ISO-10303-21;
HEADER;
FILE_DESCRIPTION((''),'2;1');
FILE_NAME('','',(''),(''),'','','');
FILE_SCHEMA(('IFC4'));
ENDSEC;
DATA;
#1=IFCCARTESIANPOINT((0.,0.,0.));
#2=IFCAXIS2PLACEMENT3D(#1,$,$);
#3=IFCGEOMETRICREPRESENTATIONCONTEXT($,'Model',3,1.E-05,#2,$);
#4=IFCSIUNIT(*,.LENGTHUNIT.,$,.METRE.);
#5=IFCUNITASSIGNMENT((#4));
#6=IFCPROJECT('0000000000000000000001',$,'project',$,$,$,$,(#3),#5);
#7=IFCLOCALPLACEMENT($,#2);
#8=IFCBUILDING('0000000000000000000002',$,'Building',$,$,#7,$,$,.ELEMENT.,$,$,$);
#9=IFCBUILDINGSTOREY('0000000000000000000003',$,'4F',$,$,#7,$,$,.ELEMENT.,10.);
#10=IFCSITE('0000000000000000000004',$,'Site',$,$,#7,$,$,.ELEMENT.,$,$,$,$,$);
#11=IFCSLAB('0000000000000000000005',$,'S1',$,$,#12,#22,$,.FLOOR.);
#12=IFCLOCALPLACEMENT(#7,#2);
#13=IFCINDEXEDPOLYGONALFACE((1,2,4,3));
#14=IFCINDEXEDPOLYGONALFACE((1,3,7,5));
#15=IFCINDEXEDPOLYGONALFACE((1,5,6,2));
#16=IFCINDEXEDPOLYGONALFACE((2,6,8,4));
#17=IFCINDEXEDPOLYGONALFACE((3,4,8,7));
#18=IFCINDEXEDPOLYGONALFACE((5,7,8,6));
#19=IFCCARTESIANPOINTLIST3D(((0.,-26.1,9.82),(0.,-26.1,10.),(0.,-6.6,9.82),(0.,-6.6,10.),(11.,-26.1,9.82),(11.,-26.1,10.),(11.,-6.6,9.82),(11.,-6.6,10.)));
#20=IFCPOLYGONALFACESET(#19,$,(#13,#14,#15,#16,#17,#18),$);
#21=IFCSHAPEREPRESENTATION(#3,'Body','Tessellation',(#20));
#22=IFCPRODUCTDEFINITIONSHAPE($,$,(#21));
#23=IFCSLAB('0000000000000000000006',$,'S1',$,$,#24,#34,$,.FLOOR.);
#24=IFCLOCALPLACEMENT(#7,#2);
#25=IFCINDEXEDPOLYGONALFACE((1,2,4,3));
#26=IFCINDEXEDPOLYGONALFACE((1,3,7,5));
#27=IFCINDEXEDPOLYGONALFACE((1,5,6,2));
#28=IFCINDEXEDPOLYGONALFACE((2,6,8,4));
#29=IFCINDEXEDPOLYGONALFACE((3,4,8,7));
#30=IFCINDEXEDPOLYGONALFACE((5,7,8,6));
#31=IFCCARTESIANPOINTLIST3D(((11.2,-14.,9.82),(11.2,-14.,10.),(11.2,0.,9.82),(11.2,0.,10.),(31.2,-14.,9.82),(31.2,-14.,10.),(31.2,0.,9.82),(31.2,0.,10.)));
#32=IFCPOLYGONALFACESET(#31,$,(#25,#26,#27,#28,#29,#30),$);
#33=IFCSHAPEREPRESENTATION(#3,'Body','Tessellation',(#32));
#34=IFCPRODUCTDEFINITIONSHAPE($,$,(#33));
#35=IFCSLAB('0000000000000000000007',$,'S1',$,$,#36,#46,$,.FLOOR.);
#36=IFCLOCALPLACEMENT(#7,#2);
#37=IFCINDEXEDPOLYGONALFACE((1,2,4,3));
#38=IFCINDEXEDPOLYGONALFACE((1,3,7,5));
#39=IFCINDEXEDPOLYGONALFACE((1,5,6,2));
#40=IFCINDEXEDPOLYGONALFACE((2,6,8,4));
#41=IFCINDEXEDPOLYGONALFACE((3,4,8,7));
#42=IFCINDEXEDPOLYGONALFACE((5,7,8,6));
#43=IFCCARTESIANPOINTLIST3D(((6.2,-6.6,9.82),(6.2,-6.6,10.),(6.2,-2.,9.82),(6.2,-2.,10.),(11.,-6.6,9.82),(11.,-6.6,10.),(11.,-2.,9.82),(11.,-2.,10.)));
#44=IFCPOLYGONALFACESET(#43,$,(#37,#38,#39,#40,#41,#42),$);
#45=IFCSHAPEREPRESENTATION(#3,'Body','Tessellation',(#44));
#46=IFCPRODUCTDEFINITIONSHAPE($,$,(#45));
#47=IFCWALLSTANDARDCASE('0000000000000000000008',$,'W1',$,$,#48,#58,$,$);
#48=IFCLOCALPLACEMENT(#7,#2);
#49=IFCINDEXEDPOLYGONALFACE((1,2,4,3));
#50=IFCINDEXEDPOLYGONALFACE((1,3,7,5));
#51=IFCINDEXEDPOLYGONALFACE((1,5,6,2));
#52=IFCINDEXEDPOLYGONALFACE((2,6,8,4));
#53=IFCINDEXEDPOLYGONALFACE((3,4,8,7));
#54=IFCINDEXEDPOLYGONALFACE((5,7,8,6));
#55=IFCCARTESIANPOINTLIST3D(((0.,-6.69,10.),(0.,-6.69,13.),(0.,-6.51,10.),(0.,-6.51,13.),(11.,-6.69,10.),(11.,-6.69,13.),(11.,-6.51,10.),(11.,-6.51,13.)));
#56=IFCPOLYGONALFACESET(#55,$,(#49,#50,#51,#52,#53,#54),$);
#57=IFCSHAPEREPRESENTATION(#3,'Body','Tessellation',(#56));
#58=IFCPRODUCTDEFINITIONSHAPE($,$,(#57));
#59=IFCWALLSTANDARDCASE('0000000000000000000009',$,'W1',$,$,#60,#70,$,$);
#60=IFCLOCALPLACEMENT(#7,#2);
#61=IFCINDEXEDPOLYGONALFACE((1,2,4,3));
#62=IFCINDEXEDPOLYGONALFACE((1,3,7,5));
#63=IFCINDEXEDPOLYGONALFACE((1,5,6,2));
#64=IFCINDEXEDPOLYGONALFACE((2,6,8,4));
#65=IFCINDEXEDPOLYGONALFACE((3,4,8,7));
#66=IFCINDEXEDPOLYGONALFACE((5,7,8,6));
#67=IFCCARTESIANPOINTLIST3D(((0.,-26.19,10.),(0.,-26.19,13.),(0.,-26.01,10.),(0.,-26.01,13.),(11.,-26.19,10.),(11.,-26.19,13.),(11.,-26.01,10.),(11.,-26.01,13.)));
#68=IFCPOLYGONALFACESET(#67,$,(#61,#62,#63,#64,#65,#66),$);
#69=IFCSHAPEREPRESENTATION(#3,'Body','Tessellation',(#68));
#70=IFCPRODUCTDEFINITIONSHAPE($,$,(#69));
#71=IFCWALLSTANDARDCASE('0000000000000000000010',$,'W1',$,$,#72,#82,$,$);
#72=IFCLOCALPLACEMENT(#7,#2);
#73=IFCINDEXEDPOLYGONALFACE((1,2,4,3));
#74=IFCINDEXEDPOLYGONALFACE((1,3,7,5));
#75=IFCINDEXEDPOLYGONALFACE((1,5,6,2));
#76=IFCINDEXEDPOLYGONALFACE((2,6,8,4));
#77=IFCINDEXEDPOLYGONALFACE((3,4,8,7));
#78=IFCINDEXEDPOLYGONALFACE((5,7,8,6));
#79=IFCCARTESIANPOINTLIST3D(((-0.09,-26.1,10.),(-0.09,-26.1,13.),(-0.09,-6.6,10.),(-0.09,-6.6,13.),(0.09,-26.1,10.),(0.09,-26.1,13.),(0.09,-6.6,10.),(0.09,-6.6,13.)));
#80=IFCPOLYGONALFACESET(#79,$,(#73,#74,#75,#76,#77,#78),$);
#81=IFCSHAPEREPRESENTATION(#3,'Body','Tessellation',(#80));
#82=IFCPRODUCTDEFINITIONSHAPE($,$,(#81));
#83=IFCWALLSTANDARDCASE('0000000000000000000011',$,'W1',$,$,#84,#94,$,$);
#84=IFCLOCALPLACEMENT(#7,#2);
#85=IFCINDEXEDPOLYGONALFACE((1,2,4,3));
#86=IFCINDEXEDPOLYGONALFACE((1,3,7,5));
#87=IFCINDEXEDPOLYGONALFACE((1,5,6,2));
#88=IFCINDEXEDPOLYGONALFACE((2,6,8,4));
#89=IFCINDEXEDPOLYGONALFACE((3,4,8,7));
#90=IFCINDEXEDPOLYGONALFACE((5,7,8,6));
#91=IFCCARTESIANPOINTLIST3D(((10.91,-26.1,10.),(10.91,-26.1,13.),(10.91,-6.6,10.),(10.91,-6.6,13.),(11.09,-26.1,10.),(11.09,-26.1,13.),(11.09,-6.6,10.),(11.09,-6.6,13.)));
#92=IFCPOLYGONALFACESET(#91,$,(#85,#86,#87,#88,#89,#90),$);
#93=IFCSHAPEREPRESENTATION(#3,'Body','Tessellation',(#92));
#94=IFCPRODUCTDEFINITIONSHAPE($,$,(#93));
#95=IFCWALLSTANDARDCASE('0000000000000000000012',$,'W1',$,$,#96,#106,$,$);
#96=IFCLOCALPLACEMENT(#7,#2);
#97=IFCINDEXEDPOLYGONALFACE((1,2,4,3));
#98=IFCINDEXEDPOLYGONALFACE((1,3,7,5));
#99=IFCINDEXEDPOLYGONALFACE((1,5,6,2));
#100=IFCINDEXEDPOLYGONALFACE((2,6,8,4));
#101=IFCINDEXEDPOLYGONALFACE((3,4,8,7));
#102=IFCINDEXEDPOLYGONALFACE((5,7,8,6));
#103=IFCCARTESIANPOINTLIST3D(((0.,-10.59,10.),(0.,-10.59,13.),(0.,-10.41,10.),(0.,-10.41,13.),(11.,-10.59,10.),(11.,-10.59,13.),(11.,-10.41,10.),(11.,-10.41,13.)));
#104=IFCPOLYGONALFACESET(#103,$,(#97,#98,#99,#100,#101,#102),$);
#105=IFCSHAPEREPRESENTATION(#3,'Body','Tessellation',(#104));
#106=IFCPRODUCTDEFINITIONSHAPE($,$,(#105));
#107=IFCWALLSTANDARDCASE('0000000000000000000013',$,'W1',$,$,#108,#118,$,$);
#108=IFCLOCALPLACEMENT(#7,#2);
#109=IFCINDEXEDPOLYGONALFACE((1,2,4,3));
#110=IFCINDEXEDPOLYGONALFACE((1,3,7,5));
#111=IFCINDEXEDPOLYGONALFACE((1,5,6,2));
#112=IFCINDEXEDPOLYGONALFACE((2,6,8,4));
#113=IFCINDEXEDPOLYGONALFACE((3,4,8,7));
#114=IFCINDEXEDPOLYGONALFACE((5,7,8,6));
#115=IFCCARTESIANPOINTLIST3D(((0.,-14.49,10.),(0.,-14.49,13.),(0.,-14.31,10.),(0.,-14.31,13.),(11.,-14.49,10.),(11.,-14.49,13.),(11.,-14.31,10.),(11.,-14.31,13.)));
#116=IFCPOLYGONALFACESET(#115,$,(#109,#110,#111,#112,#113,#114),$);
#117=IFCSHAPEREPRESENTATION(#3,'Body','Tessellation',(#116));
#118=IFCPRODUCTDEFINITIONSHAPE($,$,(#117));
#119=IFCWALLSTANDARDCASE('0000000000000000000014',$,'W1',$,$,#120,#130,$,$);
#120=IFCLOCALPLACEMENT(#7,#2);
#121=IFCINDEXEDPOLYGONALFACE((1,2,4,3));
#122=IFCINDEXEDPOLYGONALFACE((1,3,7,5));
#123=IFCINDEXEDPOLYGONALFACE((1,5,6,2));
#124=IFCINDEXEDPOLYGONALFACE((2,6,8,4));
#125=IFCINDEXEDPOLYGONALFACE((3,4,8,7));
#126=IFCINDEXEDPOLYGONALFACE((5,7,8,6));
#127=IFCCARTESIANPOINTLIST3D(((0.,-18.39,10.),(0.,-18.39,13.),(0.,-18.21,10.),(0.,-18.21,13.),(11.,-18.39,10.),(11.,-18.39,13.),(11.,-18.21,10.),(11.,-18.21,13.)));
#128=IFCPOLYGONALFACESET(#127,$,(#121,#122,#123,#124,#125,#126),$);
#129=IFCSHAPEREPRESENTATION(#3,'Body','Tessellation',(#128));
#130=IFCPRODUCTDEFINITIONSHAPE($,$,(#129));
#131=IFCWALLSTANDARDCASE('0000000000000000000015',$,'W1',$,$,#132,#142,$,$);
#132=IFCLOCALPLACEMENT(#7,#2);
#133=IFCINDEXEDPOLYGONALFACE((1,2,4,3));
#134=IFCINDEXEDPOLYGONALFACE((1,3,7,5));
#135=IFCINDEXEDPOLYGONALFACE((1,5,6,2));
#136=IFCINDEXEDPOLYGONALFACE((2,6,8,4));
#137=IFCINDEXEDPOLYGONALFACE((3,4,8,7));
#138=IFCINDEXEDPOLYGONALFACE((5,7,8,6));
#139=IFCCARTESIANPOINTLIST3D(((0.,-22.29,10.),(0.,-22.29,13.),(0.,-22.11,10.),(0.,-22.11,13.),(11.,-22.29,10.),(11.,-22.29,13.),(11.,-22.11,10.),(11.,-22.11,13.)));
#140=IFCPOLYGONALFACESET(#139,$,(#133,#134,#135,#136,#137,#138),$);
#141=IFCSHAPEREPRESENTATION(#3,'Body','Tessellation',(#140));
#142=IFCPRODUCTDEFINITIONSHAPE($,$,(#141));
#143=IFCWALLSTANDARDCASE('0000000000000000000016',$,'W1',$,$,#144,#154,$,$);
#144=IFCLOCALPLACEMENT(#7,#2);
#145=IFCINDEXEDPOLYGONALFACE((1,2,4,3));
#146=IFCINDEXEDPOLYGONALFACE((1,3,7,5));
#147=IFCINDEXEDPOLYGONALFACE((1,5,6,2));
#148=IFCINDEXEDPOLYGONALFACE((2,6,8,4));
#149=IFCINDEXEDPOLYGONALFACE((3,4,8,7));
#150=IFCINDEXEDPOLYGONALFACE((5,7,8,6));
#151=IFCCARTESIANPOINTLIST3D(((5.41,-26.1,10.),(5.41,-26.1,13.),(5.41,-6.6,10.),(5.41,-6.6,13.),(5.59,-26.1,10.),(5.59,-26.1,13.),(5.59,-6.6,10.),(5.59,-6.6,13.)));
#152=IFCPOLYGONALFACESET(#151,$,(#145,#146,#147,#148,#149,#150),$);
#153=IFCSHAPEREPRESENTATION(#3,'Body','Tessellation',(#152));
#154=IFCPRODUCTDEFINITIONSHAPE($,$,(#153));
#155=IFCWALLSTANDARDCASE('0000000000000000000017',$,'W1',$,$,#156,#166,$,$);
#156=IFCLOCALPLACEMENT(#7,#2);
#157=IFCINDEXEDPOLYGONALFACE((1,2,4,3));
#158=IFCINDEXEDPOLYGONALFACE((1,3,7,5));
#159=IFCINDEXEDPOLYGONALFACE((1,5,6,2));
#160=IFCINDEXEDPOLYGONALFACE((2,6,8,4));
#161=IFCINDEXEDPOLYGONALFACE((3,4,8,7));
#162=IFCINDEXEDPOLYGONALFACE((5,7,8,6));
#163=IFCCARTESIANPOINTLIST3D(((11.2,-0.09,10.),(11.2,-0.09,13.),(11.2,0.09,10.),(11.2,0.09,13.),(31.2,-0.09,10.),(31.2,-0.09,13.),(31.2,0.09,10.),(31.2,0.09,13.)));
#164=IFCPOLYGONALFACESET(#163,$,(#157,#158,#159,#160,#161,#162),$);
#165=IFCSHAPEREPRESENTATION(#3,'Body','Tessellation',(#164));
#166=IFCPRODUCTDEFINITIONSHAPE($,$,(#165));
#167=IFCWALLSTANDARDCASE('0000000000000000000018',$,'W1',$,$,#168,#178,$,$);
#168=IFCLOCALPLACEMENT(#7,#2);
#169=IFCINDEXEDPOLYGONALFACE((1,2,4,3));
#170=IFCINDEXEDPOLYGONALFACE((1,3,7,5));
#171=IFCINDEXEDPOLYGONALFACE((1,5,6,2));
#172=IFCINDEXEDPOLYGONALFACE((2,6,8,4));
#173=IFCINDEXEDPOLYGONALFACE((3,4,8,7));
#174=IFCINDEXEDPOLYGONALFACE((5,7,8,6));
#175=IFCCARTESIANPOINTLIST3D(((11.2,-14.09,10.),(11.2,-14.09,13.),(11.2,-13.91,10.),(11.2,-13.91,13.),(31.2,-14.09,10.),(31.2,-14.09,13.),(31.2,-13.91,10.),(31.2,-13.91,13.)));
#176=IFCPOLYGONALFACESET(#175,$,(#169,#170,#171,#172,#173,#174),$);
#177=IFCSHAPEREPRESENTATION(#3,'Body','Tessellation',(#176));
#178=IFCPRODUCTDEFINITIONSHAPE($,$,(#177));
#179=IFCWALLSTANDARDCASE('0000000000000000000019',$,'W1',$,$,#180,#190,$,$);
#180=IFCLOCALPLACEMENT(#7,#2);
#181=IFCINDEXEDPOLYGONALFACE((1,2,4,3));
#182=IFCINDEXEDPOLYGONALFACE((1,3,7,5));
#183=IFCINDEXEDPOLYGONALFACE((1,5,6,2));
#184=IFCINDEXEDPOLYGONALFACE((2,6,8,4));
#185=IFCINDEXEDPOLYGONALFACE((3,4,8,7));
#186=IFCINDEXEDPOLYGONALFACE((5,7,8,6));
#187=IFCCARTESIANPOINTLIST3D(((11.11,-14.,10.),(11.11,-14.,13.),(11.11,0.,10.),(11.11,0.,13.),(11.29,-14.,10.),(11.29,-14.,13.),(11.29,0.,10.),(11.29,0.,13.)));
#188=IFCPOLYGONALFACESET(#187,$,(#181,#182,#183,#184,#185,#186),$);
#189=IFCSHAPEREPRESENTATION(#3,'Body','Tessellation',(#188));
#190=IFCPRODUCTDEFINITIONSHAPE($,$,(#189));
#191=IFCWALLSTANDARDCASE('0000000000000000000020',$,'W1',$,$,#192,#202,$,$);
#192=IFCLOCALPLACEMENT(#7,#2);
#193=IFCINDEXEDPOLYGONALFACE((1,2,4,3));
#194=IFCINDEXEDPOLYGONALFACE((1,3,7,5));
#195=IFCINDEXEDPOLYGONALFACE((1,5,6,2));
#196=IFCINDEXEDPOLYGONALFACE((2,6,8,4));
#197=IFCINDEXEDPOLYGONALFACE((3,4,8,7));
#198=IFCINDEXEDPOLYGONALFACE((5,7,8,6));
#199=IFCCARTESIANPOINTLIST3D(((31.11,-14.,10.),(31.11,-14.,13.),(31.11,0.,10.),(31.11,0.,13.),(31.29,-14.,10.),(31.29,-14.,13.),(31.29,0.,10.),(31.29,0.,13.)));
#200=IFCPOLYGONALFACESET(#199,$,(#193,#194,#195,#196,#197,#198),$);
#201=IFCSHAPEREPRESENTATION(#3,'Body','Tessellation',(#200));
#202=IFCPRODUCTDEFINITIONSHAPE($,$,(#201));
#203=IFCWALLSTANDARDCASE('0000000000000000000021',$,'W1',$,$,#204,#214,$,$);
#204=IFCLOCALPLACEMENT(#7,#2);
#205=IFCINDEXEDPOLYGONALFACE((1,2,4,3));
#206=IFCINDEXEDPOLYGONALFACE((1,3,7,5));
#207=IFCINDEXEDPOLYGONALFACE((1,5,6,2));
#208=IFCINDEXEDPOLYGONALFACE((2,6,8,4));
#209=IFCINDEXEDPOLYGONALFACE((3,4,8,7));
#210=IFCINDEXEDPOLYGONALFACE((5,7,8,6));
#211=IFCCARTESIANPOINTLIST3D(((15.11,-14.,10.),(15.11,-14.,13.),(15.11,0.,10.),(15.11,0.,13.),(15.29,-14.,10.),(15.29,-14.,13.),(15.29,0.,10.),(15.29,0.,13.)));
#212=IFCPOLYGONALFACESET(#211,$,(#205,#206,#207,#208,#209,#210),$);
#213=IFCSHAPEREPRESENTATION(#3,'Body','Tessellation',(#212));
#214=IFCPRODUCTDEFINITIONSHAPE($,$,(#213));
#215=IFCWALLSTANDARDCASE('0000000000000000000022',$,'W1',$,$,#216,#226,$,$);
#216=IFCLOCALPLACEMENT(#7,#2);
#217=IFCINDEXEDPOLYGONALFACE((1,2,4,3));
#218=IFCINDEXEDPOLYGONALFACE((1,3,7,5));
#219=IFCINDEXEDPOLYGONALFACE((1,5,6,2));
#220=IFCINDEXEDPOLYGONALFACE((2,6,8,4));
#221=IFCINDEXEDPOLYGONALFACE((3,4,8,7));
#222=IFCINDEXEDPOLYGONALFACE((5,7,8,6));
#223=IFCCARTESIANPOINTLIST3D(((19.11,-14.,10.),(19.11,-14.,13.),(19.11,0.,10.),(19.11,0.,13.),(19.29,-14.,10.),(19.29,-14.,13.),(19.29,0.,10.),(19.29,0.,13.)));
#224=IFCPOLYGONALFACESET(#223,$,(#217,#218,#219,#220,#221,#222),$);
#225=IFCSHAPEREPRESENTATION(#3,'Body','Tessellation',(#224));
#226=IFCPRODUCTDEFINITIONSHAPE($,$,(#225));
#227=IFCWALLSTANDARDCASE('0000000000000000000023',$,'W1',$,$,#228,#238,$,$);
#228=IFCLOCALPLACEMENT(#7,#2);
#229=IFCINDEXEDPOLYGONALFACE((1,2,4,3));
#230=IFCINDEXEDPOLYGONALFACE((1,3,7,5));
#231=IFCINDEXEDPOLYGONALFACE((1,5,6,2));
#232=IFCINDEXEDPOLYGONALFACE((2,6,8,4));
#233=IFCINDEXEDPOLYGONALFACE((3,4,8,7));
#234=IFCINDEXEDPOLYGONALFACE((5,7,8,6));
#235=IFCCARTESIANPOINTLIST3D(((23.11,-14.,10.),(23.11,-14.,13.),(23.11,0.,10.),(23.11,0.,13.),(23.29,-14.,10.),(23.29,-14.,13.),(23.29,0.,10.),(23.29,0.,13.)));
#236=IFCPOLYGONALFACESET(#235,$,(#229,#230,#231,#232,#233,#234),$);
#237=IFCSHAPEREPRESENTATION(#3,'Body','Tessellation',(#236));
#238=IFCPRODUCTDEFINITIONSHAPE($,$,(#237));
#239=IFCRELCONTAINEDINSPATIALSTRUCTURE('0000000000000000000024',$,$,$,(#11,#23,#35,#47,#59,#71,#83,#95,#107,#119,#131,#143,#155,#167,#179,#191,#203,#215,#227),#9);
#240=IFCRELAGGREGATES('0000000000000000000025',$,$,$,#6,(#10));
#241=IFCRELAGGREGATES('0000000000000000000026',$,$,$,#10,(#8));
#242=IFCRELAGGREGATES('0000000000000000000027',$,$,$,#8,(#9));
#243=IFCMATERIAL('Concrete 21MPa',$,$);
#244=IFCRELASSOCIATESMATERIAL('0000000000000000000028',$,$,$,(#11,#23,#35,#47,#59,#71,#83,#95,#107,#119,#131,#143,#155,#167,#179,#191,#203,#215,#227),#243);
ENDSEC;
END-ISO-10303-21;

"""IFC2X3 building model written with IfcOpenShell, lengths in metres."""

from ifc_helpers import new_model, si_unit, frame, origin, origin_2d, place, context, project, spatial, rectangle, extrude, material, element, save


model = new_model("IFC2X3")

# Units and contexts
model_context = context("Model", 3, precision=1e-05, world=origin())
ifc_project = project(units=[si_unit("LENGTHUNIT", "METRE")], contexts=[model_context])

# Site, building, storey
placement = place(None, origin())
site = spatial("IfcSite", under=ifc_project, at=placement, Name="Site", CompositionType="ELEMENT")
building = spatial("IfcBuilding", under=site, at=placement, Name="Building", CompositionType="ELEMENT")
storey = spatial("IfcBuildingStorey", under=building, at=placement, Name="4F", CompositionType="ELEMENT", Elevation=10.0)

# Slabs
ifc_material_1 = material(Name="Concrete 21MPa")
slab_1_placement = place(None, frame((5.5, -16.35, 9.82)))
element("IfcSlab", 1, at=slab_1_placement, inside=storey, material=ifc_material_1, Name="S1", PredefinedType="FLOOR", context=model_context, shape_type="SweptSolid", body=[
    extrude(rectangle(XDim=11.0, YDim=19.5, at=origin_2d()), origin(), (0.0, 0.0, 1.0), 0.18),
])
slab_2_placement = place(None, frame((21.2, -7.0, 9.82)))
element("IfcSlab", 2, at=slab_2_placement, inside=storey, material=ifc_material_1, Name="S1", PredefinedType="FLOOR", context=model_context, shape_type="SweptSolid", body=[
    extrude(rectangle(XDim=20.0, YDim=14.0, at=origin_2d()), origin(), (0.0, 0.0, 1.0), 0.18),
])
slab_3_placement = place(None, frame((8.6, -4.3, 9.82)))
element("IfcSlab", 3, at=slab_3_placement, inside=storey, material=ifc_material_1, Name="S1", PredefinedType="FLOOR", context=model_context, shape_type="SweptSolid", body=[
    extrude(rectangle(XDim=4.8, YDim=4.6, at=origin_2d()), origin(), (0.0, 0.0, 1.0), 0.18),
])

# Walls
for number, where, name in (
    (4, (5.5, -6.6, 10.0), "W1"),
    (5, (5.5, -26.1, 10.0), "W1"),
):
    element("IfcWallStandardCase", number, at=place(None, frame(where)), inside=storey, material=ifc_material_1, Name=name, context=model_context, shape_type="SweptSolid", body=[
        extrude(rectangle(XDim=11.0, YDim=0.18, at=origin_2d()), origin(), (0.0, 0.0, 1.0), 3.0),
    ])
for number, where, name in (
    (6, (0.0, -16.35, 10.0), "W1"),
    (7, (11.0, -16.35, 10.0), "W1"),
):
    element("IfcWallStandardCase", number, at=place(None, frame(where)), inside=storey, material=ifc_material_1, Name=name, context=model_context, shape_type="SweptSolid", body=[
        extrude(rectangle(XDim=0.18, YDim=19.5, at=origin_2d()), origin(), (0.0, 0.0, 1.0), 3.0),
    ])
for number, where, name in (
    (8, (5.5, -10.5, 10.0), "W1"),
    (9, (5.5, -14.4, 10.0), "W1"),
    (10, (5.5, -18.3, 10.0), "W1"),
    (11, (5.5, -22.2, 10.0), "W1"),
):
    element("IfcWallStandardCase", number, at=place(None, frame(where)), inside=storey, material=ifc_material_1, Name=name, context=model_context, shape_type="SweptSolid", body=[
        extrude(rectangle(XDim=11.0, YDim=0.18, at=origin_2d()), origin(), (0.0, 0.0, 1.0), 3.0),
    ])
wall_1_placement = place(None, frame((5.5, -16.35, 10.0)))
element("IfcWallStandardCase", 12, at=wall_1_placement, inside=storey, material=ifc_material_1, Name="W1", context=model_context, shape_type="SweptSolid", body=[
    extrude(rectangle(XDim=0.18, YDim=19.5, at=origin_2d()), origin(), (0.0, 0.0, 1.0), 3.0),
])
for number, where, name in (
    (13, (21.2, 0.0, 10.0), "W1"),
    (14, (21.2, -14.0, 10.0), "W1"),
):
    element("IfcWallStandardCase", number, at=place(None, frame(where)), inside=storey, material=ifc_material_1, Name=name, context=model_context, shape_type="SweptSolid", body=[
        extrude(rectangle(XDim=20.0, YDim=0.18, at=origin_2d()), origin(), (0.0, 0.0, 1.0), 3.0),
    ])
for number, where, name in (
    (15, (11.2, -7.0, 10.0), "W1"),
    (16, (31.2, -7.0, 10.0), "W1"),
    (17, (15.2, -7.0, 10.0), "W1"),
    (18, (19.2, -7.0, 10.0), "W1"),
    (19, (23.2, -7.0, 10.0), "W1"),
):
    element("IfcWallStandardCase", number, at=place(None, frame(where)), inside=storey, material=ifc_material_1, Name=name, context=model_context, shape_type="SweptSolid", body=[
        extrude(rectangle(XDim=0.18, YDim=14.0, at=origin_2d()), origin(), (0.0, 0.0, 1.0), 3.0),
    ])

save(model, "model.ifc")
